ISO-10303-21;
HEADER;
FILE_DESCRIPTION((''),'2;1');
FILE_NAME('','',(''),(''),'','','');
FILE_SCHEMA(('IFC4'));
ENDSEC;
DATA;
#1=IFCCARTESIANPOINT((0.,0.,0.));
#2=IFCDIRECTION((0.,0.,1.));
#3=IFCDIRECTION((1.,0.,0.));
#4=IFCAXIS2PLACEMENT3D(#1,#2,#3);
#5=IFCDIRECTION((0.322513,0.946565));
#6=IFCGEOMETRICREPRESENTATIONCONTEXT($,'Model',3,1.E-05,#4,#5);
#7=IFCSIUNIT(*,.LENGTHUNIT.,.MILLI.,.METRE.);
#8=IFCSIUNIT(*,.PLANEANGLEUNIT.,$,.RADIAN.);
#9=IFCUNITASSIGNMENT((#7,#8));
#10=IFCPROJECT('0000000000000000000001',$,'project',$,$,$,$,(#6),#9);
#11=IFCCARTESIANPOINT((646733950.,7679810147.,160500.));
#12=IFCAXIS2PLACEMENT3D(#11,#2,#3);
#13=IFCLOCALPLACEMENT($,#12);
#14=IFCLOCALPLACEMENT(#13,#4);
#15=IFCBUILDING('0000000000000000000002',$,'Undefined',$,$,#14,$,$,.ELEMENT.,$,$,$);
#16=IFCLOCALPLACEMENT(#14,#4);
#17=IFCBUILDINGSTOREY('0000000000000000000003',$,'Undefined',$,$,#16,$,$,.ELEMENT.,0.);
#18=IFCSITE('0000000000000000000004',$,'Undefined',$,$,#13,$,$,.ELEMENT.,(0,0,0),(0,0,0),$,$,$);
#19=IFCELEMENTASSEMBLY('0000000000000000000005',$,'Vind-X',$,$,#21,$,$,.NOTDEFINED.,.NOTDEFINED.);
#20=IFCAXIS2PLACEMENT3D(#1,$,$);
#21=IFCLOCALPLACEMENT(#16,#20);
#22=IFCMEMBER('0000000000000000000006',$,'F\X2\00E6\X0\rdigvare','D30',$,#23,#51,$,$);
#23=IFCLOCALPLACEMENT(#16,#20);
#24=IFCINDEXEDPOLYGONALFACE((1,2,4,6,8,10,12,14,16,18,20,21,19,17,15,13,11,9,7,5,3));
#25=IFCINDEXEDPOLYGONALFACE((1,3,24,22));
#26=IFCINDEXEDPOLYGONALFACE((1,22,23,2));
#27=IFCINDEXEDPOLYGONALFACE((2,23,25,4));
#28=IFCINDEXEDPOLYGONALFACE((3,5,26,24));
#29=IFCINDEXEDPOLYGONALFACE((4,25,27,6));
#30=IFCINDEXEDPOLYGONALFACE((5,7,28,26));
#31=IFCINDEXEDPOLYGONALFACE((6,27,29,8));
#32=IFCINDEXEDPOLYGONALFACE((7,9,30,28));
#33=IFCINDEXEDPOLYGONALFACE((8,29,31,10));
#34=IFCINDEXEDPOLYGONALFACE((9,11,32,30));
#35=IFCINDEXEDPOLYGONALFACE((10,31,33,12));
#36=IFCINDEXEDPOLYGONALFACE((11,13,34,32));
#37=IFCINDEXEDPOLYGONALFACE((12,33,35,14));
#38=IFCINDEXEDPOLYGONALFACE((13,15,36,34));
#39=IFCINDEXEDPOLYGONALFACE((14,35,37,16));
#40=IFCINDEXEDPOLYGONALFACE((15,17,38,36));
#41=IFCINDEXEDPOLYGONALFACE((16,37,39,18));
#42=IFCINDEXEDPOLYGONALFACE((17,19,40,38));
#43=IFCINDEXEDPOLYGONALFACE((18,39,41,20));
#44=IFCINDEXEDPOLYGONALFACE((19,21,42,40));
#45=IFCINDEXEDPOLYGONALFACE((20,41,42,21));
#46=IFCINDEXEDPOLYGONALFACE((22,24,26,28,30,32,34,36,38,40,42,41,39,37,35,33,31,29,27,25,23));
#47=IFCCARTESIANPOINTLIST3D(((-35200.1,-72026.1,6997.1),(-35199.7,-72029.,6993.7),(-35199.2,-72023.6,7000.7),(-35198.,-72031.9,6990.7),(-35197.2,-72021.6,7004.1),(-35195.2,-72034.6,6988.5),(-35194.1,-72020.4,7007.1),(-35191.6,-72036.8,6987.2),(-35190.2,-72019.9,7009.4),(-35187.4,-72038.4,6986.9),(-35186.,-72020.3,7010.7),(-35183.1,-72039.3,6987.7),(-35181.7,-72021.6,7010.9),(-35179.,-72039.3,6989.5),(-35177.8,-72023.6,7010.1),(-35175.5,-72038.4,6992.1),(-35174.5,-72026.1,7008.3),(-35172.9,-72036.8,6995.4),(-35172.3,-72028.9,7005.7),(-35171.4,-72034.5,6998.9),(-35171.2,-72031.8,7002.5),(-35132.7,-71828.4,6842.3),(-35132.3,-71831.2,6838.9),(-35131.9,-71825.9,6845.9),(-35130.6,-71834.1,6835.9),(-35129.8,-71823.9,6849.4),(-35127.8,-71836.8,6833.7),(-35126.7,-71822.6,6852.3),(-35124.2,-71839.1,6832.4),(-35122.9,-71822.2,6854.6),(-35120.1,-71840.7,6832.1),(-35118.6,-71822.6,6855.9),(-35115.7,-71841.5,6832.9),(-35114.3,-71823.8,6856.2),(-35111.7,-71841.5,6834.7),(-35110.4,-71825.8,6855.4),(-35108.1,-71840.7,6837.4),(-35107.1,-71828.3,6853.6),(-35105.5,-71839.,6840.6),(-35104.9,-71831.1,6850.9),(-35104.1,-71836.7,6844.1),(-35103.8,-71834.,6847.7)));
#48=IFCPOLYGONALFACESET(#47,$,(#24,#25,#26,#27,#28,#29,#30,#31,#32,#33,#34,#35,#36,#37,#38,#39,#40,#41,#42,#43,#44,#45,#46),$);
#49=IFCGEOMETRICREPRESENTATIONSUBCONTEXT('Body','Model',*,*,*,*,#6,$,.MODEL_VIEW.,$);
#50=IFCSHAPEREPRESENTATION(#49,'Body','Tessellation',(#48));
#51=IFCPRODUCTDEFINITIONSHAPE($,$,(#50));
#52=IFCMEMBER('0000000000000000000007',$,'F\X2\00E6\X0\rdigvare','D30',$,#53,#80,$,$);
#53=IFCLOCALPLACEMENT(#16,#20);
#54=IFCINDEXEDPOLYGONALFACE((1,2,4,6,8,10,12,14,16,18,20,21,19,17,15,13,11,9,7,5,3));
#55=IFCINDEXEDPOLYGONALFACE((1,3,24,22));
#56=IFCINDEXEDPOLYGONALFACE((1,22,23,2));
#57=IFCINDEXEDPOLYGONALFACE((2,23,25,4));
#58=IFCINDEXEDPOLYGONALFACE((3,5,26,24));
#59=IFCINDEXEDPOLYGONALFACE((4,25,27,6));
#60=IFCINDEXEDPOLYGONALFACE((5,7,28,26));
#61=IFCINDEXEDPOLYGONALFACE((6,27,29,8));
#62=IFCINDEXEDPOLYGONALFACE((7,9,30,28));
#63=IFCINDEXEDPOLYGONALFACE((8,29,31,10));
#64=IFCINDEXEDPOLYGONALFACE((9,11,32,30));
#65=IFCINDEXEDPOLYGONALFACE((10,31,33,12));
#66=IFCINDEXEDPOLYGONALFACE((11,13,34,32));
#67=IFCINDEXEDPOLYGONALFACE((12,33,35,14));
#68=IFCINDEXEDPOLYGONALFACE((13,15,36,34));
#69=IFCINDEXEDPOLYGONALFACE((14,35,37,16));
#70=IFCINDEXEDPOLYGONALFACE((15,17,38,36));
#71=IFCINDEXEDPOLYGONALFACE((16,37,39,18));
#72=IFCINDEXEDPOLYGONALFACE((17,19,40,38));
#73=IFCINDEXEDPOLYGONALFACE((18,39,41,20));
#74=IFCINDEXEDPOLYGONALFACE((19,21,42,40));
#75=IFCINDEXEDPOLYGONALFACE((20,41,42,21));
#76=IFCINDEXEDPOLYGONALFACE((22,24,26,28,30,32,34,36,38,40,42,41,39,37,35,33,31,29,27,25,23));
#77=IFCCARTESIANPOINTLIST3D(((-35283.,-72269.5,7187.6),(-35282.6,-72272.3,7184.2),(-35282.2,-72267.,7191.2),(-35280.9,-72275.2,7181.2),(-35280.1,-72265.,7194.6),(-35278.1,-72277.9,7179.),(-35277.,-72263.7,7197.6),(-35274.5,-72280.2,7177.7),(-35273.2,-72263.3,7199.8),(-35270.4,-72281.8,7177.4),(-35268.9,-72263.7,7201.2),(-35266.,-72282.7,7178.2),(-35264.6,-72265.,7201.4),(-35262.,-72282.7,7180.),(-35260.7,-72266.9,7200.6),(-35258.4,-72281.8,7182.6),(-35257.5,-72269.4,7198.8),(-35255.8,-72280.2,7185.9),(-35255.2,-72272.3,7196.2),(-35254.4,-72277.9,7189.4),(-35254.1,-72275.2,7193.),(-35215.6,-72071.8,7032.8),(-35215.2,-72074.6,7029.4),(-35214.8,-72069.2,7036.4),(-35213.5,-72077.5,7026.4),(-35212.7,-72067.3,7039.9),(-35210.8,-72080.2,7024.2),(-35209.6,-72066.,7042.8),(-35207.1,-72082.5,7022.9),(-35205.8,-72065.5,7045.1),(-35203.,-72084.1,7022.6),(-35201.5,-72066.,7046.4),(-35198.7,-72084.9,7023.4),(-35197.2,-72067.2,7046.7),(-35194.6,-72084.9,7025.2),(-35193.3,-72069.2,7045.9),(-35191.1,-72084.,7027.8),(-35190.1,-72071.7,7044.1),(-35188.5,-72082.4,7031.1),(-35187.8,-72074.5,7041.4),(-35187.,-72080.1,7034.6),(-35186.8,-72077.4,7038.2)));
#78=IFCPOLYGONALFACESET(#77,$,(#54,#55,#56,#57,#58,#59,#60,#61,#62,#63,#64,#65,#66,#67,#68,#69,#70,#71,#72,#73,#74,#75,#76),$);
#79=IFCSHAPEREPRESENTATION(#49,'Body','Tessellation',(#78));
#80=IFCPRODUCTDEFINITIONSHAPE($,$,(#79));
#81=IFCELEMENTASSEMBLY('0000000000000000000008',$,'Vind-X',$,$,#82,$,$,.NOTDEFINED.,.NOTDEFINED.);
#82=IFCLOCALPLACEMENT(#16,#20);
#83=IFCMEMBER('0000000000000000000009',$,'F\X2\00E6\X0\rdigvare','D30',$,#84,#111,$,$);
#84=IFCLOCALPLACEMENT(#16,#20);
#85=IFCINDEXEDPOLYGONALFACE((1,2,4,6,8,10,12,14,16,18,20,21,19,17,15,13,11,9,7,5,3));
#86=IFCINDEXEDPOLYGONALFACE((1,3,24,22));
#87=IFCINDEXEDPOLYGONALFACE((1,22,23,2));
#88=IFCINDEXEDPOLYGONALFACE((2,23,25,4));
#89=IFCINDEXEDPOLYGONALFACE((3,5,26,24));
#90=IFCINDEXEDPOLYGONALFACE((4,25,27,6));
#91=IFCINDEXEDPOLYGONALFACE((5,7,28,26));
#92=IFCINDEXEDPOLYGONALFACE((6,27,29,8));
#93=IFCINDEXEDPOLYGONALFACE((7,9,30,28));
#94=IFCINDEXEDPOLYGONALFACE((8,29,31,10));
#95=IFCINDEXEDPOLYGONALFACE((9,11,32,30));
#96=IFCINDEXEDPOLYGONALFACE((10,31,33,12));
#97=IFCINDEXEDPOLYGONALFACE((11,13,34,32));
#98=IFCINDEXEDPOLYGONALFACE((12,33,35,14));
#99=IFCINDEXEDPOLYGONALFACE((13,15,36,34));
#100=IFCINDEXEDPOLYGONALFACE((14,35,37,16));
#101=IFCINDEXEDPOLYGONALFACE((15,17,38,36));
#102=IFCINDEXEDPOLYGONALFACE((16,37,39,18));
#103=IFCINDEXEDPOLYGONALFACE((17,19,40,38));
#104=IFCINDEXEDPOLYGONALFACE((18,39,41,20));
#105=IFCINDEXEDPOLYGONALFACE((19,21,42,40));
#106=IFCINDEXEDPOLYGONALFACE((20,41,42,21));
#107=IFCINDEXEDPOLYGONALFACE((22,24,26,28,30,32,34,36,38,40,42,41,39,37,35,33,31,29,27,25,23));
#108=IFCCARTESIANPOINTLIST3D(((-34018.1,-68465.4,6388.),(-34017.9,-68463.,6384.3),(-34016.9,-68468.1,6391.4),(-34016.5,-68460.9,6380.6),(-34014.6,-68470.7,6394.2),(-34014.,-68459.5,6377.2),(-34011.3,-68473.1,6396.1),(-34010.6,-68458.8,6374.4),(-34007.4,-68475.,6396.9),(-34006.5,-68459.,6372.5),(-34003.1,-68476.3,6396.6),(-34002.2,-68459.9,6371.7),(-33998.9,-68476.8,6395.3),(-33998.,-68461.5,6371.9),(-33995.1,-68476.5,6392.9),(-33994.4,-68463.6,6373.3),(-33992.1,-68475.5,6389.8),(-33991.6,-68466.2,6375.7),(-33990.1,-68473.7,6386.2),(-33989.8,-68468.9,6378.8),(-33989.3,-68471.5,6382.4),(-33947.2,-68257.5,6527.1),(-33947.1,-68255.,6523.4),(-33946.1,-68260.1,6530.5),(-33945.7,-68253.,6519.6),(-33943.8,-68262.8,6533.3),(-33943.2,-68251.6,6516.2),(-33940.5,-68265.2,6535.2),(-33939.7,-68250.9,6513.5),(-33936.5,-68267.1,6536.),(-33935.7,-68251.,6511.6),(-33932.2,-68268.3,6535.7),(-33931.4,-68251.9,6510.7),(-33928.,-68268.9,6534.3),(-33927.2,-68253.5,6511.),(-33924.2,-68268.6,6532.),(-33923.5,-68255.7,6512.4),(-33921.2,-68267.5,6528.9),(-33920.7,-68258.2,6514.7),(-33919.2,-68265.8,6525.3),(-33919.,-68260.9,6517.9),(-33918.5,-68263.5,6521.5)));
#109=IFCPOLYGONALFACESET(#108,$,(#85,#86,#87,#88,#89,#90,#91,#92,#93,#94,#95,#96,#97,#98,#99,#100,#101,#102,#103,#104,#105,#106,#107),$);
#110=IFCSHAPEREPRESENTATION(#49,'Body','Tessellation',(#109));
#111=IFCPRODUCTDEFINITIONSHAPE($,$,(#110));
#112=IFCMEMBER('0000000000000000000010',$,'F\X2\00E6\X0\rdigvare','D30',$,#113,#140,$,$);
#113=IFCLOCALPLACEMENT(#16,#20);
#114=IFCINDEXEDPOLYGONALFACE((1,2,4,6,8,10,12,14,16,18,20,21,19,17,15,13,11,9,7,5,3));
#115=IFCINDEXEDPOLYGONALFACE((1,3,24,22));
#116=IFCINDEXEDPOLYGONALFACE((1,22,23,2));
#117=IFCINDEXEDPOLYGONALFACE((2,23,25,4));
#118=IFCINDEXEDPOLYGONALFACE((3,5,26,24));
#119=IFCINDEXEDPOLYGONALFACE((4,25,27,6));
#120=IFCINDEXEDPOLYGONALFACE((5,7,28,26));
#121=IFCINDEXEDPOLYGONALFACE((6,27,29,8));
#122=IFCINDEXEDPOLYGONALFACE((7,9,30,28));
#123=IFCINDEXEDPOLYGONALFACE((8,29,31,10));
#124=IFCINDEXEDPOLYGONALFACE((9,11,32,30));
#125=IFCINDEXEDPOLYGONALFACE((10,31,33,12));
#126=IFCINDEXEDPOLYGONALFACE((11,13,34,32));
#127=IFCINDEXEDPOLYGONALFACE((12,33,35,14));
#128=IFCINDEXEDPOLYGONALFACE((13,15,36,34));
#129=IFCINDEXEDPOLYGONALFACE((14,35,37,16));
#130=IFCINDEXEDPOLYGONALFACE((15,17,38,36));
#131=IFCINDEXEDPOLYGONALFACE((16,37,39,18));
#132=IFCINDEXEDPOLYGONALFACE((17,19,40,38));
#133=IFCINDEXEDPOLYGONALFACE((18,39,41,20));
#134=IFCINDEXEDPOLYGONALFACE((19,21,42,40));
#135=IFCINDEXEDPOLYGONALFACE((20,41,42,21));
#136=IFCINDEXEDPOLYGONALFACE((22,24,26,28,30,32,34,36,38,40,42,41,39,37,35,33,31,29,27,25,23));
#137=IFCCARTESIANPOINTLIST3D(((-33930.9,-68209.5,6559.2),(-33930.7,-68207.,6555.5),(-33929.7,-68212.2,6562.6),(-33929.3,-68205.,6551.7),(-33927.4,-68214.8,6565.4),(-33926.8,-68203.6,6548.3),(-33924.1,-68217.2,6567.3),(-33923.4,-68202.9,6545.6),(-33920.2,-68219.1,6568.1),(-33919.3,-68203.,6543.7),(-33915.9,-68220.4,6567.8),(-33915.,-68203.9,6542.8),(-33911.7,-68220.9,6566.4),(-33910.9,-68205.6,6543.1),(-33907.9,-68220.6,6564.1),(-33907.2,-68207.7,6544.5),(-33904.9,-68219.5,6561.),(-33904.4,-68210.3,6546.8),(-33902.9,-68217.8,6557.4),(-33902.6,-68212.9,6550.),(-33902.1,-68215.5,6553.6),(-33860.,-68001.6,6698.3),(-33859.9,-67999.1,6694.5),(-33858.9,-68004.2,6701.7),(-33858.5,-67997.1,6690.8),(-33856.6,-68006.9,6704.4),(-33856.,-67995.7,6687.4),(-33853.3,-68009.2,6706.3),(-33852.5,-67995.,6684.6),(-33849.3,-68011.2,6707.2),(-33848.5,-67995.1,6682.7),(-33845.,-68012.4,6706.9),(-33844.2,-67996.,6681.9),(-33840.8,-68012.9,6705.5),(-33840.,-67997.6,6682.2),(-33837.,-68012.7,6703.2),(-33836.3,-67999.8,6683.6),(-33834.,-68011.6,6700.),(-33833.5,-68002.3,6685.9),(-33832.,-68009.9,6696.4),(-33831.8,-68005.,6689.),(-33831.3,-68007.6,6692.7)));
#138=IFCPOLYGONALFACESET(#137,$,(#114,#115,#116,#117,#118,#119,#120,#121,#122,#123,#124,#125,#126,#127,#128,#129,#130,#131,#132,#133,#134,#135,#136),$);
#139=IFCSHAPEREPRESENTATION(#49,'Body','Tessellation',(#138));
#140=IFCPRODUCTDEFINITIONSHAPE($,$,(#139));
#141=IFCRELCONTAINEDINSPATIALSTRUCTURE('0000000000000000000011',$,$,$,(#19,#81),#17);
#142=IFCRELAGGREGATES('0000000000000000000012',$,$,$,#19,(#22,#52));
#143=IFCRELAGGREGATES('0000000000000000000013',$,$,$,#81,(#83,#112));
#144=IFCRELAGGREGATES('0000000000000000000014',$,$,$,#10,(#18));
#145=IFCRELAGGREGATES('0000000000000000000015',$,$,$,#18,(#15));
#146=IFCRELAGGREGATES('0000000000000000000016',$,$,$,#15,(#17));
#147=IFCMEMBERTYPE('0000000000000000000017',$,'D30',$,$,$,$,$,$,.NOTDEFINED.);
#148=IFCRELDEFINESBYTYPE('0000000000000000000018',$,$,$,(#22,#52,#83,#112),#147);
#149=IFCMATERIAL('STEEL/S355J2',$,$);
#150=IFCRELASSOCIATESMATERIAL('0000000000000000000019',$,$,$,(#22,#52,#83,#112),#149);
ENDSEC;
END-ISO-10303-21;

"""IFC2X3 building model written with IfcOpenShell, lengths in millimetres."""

from ifc_helpers import new_model, si_unit, direction, frame, origin_with_axes, origin_2d_with_axis, place, context, subcontext, project, spatial, circle, extrude, material, type_object, element, aggregate, save


model = new_model("IFC2X3")

# Units and contexts
model_context = context("Model", 3, precision=1e-05, world=origin_with_axes(), true_north=direction((0.322513, 0.946565)))
body_context = subcontext(model_context, "Body", "Model", "MODEL_VIEW")
ifc_project = project(units=[si_unit("LENGTHUNIT", "METRE", prefix="MILLI"), si_unit("PLANEANGLEUNIT", "RADIAN")], contexts=[model_context])

# Site, building, storey
site_placement = place(None, frame((646733950.0, 7679810147.0, 160500.0), z_axis=(0.0, 0.0, 1.0), x_axis=(1.0, 0.0, 0.0)))
site = spatial("IfcSite", under=ifc_project, at=site_placement, Name="Undefined", CompositionType="ELEMENT", RefLatitude=(0, 0, 0), RefLongitude=(0, 0, 0))
building_placement = place(site_placement, origin_with_axes())
building = spatial("IfcBuilding", under=site, at=building_placement, Name="Undefined", CompositionType="ELEMENT")
storey_placement = place(building_placement, origin_with_axes())
storey = spatial("IfcBuildingStorey", under=building, at=storey_placement, Name="Undefined", CompositionType="ELEMENT", Elevation=0.0)

# Element assemblies, members
assembly_1_placement = place(storey_placement, origin_with_axes())
assembly_1 = element("IfcElementAssembly", 1, at=assembly_1_placement, inside=storey, Name="Vind-X", AssemblyPlace="NOTDEFINED", PredefinedType="NOTDEFINED")
ifc_material_1 = material(Name="STEEL/S355J2")
member_type_1 = type_object("IfcMemberType", Name="D30", PredefinedType="NOTDEFINED")
member_1_placement = place(assembly_1_placement, frame((-35185.6, -72029.7, 6998.9), z_axis=(0.191985, 0.56347, 0.803519), x_axis=(0.259145, 0.760583, -0.595279)))
member_1 = element("IfcMember", 2, at=member_1_placement, type_object=member_type_1, material=ifc_material_1, Name="Færdigvare", Description="D30", context=body_context, shape_type="SweptSolid", body=[
    extrude(circle(Radius=15.0, at=origin_2d_with_axis()), frame((260.0, 0.0, 0.0), z_axis=(-1.0, 0.0, 0.0), x_axis=(0.0, -1.0, 0.0)), (0.0, 0.0, 1.0), 260.0),
])
member_2_placement = place(assembly_1_placement, frame((-35268.6, -72273.0, 7189.4), z_axis=(0.191985, 0.563471, 0.803519), x_axis=(0.259145, 0.760583, -0.595279)))
member_2 = element("IfcMember", 3, at=member_2_placement, type_object=member_type_1, material=ifc_material_1, Name="Færdigvare", Description="D30", context=body_context, shape_type="SweptSolid", body=[
    extrude(circle(Radius=15.0, at=origin_2d_with_axis()), frame((260.0, 0.0, 0.0), z_axis=(-1.0, 0.0, 0.0), x_axis=(0.0, -1.0, 0.0)), (0.0, 0.0, 1.0), 260.0),
])
assembly_2_placement = place(storey_placement, origin_with_axes())
assembly_2 = element("IfcElementAssembly", 4, at=assembly_2_placement, inside=storey, Name="Vind-X", AssemblyPlace="NOTDEFINED", PredefinedType="NOTDEFINED")
member_3_placement = place(assembly_2_placement, frame((-33932.9, -68259.9, 6523.4), z_axis=(-0.172512, -0.506317, 0.844916), x_axis=(-0.272496, -0.799768, -0.5349)))
member_3 = element("IfcMember", 5, at=member_3_placement, type_object=member_type_1, material=ifc_material_1, Name="Færdigvare", Description="D30", context=body_context, shape_type="SweptSolid", body=[
    extrude(circle(Radius=15.0, at=origin_2d_with_axis()), frame((260.0, 0.0, 0.0), z_axis=(-1.0, 0.0, 0.0), x_axis=(0.0, -1.0, 0.0)), (0.0, 0.0, 1.0), 260.0),
])
member_4_placement = place(assembly_2_placement, frame((-33845.7, -68003.9, 6694.5), z_axis=(-0.172512, -0.506318, 0.844915), x_axis=(-0.272496, -0.799767, -0.5349)))
member_4 = element("IfcMember", 6, at=member_4_placement, type_object=member_type_1, material=ifc_material_1, Name="Færdigvare", Description="D30", context=body_context, shape_type="SweptSolid", body=[
    extrude(circle(Radius=15.0, at=origin_2d_with_axis()), frame((260.0, 0.0, 0.0), z_axis=(-1.0, 0.0, 0.0), x_axis=(0.0, -1.0, 0.0)), (0.0, 0.0, 1.0), 260.0),
])

aggregate(assembly_1, [member_1, member_2])
aggregate(assembly_2, [member_3, member_4])

save(model, "model.ifc")
